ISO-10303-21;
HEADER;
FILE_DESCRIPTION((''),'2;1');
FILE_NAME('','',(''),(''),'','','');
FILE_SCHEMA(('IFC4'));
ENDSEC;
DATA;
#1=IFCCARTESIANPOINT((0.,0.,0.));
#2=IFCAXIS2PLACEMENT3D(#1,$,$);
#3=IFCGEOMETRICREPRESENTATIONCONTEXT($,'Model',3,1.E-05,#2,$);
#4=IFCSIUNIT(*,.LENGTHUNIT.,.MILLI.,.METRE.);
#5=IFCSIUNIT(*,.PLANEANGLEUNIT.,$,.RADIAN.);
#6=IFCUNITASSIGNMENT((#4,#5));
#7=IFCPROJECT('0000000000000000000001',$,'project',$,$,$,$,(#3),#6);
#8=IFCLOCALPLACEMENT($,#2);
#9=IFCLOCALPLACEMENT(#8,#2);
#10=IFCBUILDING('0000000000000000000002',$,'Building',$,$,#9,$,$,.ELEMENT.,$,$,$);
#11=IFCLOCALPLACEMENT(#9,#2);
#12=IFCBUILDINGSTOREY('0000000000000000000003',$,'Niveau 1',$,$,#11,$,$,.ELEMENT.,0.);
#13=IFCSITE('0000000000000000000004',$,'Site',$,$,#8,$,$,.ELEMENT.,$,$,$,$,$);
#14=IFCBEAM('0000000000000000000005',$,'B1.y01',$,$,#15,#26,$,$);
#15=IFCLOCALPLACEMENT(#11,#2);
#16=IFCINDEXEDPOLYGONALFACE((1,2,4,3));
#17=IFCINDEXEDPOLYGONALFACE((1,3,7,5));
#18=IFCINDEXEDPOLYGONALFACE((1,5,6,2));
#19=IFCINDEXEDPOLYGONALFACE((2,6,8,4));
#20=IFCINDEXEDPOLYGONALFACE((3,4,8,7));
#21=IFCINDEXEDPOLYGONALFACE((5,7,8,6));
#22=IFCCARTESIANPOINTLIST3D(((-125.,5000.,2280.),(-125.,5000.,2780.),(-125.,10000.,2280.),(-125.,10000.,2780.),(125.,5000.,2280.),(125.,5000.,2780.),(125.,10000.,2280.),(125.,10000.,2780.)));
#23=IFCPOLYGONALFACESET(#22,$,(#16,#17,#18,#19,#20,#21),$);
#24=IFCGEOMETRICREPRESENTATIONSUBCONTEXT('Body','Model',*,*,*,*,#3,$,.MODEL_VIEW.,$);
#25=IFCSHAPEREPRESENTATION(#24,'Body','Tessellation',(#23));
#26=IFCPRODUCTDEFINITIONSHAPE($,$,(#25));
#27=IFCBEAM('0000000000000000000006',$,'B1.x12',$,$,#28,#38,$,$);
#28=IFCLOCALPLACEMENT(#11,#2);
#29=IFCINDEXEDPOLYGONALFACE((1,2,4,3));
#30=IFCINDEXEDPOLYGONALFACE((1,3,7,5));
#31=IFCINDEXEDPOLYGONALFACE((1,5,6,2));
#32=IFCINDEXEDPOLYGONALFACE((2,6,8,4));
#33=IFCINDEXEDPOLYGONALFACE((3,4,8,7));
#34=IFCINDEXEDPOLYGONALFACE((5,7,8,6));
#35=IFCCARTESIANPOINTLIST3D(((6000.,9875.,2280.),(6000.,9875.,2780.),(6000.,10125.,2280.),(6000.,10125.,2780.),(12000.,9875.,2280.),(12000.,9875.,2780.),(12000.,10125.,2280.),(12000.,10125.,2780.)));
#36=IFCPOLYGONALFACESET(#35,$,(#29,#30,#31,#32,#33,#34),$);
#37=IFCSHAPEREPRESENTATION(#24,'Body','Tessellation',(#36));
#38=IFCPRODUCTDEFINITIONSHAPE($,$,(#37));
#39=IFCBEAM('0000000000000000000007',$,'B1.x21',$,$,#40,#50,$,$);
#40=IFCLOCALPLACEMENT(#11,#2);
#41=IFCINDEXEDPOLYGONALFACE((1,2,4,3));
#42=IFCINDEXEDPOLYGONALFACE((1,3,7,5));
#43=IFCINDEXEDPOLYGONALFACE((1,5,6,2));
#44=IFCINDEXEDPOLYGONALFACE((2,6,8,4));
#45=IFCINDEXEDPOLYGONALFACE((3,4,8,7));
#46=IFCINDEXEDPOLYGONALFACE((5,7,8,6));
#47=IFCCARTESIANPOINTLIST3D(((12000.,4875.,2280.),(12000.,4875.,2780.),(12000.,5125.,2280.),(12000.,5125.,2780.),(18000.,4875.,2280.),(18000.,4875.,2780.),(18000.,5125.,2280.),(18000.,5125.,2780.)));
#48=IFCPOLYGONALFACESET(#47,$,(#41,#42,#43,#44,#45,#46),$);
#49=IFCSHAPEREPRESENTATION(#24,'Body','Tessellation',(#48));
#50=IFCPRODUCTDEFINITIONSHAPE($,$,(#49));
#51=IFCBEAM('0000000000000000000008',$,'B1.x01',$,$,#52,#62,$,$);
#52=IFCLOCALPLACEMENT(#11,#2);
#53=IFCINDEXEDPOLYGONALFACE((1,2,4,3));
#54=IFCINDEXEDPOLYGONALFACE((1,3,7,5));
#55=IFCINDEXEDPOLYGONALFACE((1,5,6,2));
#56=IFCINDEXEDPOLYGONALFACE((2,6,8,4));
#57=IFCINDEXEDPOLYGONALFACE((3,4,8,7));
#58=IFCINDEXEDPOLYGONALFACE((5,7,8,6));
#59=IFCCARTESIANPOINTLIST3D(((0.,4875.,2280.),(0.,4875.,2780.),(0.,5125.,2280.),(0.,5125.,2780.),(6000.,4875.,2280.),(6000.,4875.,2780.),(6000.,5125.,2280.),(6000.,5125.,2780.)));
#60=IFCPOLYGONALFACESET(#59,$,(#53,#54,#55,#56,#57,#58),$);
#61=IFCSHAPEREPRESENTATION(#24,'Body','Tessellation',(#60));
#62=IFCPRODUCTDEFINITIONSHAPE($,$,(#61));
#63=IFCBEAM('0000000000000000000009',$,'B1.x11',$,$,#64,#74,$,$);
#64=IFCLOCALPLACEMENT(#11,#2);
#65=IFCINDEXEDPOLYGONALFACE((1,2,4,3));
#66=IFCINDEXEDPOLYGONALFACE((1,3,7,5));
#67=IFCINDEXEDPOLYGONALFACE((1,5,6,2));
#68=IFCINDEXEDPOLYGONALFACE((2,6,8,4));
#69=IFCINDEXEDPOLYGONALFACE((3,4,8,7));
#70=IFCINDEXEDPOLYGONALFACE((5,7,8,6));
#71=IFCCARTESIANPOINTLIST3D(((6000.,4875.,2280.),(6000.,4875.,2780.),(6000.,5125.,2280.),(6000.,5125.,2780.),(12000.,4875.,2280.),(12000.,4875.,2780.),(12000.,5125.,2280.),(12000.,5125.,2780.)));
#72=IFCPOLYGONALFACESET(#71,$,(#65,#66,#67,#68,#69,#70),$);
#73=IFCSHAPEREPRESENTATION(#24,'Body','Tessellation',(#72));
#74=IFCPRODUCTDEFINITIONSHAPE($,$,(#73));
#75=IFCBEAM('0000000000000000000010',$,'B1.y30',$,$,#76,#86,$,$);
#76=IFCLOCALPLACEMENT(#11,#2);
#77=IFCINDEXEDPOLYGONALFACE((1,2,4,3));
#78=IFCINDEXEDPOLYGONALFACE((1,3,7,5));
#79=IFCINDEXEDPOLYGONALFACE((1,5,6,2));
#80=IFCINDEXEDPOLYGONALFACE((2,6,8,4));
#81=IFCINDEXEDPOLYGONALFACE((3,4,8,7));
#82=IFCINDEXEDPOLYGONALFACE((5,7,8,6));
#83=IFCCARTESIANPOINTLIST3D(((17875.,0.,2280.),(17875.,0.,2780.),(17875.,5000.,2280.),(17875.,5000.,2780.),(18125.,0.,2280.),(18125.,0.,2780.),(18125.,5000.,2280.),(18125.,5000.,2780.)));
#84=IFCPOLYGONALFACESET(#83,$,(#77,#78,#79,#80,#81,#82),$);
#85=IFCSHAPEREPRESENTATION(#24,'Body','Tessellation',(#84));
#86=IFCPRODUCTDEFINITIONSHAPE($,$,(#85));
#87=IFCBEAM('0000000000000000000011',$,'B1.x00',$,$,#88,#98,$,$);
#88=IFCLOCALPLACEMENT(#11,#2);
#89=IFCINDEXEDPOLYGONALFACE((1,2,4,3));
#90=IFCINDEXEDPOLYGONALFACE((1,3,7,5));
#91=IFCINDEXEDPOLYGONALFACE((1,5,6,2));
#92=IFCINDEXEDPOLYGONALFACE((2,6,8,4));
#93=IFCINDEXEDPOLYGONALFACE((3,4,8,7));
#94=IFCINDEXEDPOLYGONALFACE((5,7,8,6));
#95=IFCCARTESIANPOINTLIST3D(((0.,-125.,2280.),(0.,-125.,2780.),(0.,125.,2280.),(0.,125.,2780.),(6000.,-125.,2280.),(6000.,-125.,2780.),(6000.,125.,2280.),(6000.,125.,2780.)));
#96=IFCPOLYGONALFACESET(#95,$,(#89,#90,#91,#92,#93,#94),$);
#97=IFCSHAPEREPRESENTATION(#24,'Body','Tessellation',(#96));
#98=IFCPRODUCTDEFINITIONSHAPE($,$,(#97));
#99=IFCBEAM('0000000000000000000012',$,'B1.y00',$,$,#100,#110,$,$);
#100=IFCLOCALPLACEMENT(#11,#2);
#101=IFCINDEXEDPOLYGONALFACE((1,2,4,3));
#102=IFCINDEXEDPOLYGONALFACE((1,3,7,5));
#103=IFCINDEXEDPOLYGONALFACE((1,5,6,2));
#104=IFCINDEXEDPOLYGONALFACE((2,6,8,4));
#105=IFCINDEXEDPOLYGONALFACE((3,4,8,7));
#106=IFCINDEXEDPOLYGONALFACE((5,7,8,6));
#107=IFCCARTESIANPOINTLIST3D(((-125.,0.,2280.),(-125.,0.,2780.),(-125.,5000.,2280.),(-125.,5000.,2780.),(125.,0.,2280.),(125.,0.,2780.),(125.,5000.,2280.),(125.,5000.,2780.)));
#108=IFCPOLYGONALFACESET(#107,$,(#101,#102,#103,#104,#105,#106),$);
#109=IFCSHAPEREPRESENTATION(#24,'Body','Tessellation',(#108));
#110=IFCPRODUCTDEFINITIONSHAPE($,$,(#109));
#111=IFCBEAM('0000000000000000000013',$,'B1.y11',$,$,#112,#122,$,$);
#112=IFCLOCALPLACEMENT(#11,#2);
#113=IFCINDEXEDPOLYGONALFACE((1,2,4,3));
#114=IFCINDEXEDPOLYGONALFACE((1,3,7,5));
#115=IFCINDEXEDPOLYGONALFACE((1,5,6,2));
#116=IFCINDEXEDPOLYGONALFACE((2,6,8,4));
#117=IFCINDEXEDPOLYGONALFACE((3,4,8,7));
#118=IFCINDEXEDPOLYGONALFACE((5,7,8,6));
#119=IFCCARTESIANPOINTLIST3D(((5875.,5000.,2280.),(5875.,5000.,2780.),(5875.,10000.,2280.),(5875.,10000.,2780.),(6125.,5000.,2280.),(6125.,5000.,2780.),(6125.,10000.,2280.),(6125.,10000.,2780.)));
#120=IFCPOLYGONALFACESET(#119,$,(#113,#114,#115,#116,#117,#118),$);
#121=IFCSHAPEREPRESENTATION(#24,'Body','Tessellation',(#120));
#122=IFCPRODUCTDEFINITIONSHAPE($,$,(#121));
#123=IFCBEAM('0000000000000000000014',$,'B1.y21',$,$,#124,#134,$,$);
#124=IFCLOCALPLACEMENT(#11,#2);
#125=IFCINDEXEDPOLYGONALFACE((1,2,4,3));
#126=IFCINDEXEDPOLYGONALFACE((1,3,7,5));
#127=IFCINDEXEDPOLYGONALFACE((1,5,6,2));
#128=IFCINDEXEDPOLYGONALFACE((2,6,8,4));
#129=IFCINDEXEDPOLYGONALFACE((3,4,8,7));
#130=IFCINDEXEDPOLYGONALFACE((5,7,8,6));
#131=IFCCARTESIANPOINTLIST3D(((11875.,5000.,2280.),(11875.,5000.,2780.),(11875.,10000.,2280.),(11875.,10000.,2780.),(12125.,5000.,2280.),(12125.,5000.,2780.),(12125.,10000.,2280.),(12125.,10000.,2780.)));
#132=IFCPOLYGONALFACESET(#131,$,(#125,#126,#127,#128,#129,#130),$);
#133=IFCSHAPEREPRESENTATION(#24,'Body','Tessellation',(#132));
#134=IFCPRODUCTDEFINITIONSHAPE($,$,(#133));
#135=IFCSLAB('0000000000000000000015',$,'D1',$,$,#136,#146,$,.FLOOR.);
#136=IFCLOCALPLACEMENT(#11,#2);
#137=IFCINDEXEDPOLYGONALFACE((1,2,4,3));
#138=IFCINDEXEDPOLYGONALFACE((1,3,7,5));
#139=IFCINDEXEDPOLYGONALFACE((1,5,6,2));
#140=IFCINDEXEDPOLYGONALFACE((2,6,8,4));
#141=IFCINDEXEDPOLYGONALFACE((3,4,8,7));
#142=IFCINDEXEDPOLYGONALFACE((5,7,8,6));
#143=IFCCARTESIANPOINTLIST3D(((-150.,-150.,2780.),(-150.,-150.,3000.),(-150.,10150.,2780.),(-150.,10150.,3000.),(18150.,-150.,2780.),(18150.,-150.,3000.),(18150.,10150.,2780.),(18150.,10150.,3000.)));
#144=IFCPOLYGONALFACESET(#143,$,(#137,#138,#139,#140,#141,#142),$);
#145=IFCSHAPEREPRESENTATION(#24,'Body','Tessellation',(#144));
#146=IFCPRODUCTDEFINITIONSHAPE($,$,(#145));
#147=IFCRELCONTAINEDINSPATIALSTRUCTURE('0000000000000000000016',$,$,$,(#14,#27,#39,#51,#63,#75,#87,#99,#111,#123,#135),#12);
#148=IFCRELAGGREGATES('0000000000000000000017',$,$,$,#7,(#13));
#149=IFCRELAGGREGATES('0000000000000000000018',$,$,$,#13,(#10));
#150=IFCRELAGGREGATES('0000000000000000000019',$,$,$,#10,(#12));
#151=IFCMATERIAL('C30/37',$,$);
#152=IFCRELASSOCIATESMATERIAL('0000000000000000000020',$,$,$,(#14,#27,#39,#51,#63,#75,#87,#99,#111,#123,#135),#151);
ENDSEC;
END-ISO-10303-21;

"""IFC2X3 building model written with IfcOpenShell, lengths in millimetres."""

from ifc_helpers import new_model, si_unit, frame, origin, origin_2d, place, context, subcontext, project, spatial, polyline, rectangle, outline, extrude, material, element, save


model = new_model("IFC2X3")

# Units and contexts
model_context = context("Model", 3, precision=1e-05, world=origin())
body_context = subcontext(model_context, "Body", "Model", "MODEL_VIEW")
ifc_project = project(units=[si_unit("LENGTHUNIT", "METRE", prefix="MILLI"), si_unit("PLANEANGLEUNIT", "RADIAN")], contexts=[model_context])

# Site, building, storey
site_placement = place(None, origin())
site = spatial("IfcSite", under=ifc_project, at=site_placement, Name="Site", CompositionType="ELEMENT")
building_placement = place(site_placement, origin())
building = spatial("IfcBuilding", under=site, at=building_placement, Name="Building", CompositionType="ELEMENT")
storey_placement = place(building_placement, origin())
storey = spatial("IfcBuildingStorey", under=building, at=storey_placement, Name="Niveau 1", CompositionType="ELEMENT", Elevation=0.0)

# Shared definitions
ifc_material = material(Name="C30/37")

# Beams
beam_1_placement = place(storey_placement, frame((0.0, 5000.0, 2530.0), z_axis=(0.0, 1.0, 0.0), x_axis=(-1.0, 0.0, 0.0)))
element("IfcBeam", 1, at=beam_1_placement, inside=storey, material=ifc_material, Name="B1.y01", context=body_context, shape_type="SweptSolid", body=[
    extrude(rectangle(XDim=250.0, YDim=500.0, at=origin_2d()), origin(), (0.0, 0.0, 1.0), 5000.0),
])
for number, where, z_axis, x_axis, name in (
    (2, (6000.0, 10000.0, 2530.0), (1.0, 0.0, 0.0), (0.0, 1.0, 0.0), "B1.x12"),
    (3, (12000.0, 5000.0, 2530.0), (1.0, 0.0, 0.0), (0.0, 1.0, 0.0), "B1.x21"),
    (4, (0.0, 5000.0, 2530.0), (1.0, 0.0, 0.0), (0.0, 1.0, 0.0), "B1.x01"),
    (5, (6000.0, 5000.0, 2530.0), (1.0, 0.0, 0.0), (0.0, 1.0, 0.0), "B1.x11"),
):
    element("IfcBeam", number, at=place(storey_placement, frame(where, z_axis=z_axis, x_axis=x_axis)), inside=storey, material=ifc_material, Name=name, context=body_context, shape_type="SweptSolid", body=[
        extrude(rectangle(XDim=250.0, YDim=500.0, at=origin_2d()), origin(), (0.0, 0.0, 1.0), 6000.0),
    ])
beam_2_placement = place(storey_placement, frame((18000.0, 0.0, 2530.0), z_axis=(0.0, 1.0, 0.0), x_axis=(-1.0, 0.0, 0.0)))
element("IfcBeam", 6, at=beam_2_placement, inside=storey, material=ifc_material, Name="B1.y30", context=body_context, shape_type="SweptSolid", body=[
    extrude(rectangle(XDim=250.0, YDim=500.0, at=origin_2d()), origin(), (0.0, 0.0, 1.0), 5000.0),
])
beam_3_placement = place(storey_placement, frame((0.0, 0.0, 2530.0), z_axis=(1.0, 0.0, 0.0), x_axis=(0.0, 1.0, 0.0)))
element("IfcBeam", 7, at=beam_3_placement, inside=storey, material=ifc_material, Name="B1.x00", context=body_context, shape_type="SweptSolid", body=[
    extrude(rectangle(XDim=250.0, YDim=500.0, at=origin_2d()), origin(), (0.0, 0.0, 1.0), 6000.0),
])
for number, where, z_axis, x_axis, name in (
    (8, (0.0, 0.0, 2530.0), (0.0, 1.0, 0.0), (-1.0, 0.0, 0.0), "B1.y00"),
    (9, (6000.0, 5000.0, 2530.0), (0.0, 1.0, 0.0), (-1.0, 0.0, 0.0), "B1.y11"),
    (10, (12000.0, 5000.0, 2530.0), (0.0, 1.0, 0.0), (-1.0, 0.0, 0.0), "B1.y21"),
):
    element("IfcBeam", number, at=place(storey_placement, frame(where, z_axis=z_axis, x_axis=x_axis)), inside=storey, material=ifc_material, Name=name, context=body_context, shape_type="SweptSolid", body=[
        extrude(rectangle(XDim=250.0, YDim=500.0, at=origin_2d()), origin(), (0.0, 0.0, 1.0), 5000.0),
    ])

# Slab
slab_placement = place(storey_placement, frame((0.0, 0.0, 2780.0), z_axis=(0.0, 0.0, 1.0), x_axis=(1.0, 0.0, 0.0)))
element("IfcSlab", 11, at=slab_placement, inside=storey, material=ifc_material, Name="D1", PredefinedType="FLOOR", context=body_context, shape_type="SweptSolid", body=[
    extrude(outline(polyline([(-150.0, -150.0), (18150.0, -150.0), (18150.0, 10150.0), (-150.0, 10150.0), (-150.0, -150.0)])), origin(), (0.0, 0.0, 1.0), 220.0),
])

save(model, "model.ifc")
